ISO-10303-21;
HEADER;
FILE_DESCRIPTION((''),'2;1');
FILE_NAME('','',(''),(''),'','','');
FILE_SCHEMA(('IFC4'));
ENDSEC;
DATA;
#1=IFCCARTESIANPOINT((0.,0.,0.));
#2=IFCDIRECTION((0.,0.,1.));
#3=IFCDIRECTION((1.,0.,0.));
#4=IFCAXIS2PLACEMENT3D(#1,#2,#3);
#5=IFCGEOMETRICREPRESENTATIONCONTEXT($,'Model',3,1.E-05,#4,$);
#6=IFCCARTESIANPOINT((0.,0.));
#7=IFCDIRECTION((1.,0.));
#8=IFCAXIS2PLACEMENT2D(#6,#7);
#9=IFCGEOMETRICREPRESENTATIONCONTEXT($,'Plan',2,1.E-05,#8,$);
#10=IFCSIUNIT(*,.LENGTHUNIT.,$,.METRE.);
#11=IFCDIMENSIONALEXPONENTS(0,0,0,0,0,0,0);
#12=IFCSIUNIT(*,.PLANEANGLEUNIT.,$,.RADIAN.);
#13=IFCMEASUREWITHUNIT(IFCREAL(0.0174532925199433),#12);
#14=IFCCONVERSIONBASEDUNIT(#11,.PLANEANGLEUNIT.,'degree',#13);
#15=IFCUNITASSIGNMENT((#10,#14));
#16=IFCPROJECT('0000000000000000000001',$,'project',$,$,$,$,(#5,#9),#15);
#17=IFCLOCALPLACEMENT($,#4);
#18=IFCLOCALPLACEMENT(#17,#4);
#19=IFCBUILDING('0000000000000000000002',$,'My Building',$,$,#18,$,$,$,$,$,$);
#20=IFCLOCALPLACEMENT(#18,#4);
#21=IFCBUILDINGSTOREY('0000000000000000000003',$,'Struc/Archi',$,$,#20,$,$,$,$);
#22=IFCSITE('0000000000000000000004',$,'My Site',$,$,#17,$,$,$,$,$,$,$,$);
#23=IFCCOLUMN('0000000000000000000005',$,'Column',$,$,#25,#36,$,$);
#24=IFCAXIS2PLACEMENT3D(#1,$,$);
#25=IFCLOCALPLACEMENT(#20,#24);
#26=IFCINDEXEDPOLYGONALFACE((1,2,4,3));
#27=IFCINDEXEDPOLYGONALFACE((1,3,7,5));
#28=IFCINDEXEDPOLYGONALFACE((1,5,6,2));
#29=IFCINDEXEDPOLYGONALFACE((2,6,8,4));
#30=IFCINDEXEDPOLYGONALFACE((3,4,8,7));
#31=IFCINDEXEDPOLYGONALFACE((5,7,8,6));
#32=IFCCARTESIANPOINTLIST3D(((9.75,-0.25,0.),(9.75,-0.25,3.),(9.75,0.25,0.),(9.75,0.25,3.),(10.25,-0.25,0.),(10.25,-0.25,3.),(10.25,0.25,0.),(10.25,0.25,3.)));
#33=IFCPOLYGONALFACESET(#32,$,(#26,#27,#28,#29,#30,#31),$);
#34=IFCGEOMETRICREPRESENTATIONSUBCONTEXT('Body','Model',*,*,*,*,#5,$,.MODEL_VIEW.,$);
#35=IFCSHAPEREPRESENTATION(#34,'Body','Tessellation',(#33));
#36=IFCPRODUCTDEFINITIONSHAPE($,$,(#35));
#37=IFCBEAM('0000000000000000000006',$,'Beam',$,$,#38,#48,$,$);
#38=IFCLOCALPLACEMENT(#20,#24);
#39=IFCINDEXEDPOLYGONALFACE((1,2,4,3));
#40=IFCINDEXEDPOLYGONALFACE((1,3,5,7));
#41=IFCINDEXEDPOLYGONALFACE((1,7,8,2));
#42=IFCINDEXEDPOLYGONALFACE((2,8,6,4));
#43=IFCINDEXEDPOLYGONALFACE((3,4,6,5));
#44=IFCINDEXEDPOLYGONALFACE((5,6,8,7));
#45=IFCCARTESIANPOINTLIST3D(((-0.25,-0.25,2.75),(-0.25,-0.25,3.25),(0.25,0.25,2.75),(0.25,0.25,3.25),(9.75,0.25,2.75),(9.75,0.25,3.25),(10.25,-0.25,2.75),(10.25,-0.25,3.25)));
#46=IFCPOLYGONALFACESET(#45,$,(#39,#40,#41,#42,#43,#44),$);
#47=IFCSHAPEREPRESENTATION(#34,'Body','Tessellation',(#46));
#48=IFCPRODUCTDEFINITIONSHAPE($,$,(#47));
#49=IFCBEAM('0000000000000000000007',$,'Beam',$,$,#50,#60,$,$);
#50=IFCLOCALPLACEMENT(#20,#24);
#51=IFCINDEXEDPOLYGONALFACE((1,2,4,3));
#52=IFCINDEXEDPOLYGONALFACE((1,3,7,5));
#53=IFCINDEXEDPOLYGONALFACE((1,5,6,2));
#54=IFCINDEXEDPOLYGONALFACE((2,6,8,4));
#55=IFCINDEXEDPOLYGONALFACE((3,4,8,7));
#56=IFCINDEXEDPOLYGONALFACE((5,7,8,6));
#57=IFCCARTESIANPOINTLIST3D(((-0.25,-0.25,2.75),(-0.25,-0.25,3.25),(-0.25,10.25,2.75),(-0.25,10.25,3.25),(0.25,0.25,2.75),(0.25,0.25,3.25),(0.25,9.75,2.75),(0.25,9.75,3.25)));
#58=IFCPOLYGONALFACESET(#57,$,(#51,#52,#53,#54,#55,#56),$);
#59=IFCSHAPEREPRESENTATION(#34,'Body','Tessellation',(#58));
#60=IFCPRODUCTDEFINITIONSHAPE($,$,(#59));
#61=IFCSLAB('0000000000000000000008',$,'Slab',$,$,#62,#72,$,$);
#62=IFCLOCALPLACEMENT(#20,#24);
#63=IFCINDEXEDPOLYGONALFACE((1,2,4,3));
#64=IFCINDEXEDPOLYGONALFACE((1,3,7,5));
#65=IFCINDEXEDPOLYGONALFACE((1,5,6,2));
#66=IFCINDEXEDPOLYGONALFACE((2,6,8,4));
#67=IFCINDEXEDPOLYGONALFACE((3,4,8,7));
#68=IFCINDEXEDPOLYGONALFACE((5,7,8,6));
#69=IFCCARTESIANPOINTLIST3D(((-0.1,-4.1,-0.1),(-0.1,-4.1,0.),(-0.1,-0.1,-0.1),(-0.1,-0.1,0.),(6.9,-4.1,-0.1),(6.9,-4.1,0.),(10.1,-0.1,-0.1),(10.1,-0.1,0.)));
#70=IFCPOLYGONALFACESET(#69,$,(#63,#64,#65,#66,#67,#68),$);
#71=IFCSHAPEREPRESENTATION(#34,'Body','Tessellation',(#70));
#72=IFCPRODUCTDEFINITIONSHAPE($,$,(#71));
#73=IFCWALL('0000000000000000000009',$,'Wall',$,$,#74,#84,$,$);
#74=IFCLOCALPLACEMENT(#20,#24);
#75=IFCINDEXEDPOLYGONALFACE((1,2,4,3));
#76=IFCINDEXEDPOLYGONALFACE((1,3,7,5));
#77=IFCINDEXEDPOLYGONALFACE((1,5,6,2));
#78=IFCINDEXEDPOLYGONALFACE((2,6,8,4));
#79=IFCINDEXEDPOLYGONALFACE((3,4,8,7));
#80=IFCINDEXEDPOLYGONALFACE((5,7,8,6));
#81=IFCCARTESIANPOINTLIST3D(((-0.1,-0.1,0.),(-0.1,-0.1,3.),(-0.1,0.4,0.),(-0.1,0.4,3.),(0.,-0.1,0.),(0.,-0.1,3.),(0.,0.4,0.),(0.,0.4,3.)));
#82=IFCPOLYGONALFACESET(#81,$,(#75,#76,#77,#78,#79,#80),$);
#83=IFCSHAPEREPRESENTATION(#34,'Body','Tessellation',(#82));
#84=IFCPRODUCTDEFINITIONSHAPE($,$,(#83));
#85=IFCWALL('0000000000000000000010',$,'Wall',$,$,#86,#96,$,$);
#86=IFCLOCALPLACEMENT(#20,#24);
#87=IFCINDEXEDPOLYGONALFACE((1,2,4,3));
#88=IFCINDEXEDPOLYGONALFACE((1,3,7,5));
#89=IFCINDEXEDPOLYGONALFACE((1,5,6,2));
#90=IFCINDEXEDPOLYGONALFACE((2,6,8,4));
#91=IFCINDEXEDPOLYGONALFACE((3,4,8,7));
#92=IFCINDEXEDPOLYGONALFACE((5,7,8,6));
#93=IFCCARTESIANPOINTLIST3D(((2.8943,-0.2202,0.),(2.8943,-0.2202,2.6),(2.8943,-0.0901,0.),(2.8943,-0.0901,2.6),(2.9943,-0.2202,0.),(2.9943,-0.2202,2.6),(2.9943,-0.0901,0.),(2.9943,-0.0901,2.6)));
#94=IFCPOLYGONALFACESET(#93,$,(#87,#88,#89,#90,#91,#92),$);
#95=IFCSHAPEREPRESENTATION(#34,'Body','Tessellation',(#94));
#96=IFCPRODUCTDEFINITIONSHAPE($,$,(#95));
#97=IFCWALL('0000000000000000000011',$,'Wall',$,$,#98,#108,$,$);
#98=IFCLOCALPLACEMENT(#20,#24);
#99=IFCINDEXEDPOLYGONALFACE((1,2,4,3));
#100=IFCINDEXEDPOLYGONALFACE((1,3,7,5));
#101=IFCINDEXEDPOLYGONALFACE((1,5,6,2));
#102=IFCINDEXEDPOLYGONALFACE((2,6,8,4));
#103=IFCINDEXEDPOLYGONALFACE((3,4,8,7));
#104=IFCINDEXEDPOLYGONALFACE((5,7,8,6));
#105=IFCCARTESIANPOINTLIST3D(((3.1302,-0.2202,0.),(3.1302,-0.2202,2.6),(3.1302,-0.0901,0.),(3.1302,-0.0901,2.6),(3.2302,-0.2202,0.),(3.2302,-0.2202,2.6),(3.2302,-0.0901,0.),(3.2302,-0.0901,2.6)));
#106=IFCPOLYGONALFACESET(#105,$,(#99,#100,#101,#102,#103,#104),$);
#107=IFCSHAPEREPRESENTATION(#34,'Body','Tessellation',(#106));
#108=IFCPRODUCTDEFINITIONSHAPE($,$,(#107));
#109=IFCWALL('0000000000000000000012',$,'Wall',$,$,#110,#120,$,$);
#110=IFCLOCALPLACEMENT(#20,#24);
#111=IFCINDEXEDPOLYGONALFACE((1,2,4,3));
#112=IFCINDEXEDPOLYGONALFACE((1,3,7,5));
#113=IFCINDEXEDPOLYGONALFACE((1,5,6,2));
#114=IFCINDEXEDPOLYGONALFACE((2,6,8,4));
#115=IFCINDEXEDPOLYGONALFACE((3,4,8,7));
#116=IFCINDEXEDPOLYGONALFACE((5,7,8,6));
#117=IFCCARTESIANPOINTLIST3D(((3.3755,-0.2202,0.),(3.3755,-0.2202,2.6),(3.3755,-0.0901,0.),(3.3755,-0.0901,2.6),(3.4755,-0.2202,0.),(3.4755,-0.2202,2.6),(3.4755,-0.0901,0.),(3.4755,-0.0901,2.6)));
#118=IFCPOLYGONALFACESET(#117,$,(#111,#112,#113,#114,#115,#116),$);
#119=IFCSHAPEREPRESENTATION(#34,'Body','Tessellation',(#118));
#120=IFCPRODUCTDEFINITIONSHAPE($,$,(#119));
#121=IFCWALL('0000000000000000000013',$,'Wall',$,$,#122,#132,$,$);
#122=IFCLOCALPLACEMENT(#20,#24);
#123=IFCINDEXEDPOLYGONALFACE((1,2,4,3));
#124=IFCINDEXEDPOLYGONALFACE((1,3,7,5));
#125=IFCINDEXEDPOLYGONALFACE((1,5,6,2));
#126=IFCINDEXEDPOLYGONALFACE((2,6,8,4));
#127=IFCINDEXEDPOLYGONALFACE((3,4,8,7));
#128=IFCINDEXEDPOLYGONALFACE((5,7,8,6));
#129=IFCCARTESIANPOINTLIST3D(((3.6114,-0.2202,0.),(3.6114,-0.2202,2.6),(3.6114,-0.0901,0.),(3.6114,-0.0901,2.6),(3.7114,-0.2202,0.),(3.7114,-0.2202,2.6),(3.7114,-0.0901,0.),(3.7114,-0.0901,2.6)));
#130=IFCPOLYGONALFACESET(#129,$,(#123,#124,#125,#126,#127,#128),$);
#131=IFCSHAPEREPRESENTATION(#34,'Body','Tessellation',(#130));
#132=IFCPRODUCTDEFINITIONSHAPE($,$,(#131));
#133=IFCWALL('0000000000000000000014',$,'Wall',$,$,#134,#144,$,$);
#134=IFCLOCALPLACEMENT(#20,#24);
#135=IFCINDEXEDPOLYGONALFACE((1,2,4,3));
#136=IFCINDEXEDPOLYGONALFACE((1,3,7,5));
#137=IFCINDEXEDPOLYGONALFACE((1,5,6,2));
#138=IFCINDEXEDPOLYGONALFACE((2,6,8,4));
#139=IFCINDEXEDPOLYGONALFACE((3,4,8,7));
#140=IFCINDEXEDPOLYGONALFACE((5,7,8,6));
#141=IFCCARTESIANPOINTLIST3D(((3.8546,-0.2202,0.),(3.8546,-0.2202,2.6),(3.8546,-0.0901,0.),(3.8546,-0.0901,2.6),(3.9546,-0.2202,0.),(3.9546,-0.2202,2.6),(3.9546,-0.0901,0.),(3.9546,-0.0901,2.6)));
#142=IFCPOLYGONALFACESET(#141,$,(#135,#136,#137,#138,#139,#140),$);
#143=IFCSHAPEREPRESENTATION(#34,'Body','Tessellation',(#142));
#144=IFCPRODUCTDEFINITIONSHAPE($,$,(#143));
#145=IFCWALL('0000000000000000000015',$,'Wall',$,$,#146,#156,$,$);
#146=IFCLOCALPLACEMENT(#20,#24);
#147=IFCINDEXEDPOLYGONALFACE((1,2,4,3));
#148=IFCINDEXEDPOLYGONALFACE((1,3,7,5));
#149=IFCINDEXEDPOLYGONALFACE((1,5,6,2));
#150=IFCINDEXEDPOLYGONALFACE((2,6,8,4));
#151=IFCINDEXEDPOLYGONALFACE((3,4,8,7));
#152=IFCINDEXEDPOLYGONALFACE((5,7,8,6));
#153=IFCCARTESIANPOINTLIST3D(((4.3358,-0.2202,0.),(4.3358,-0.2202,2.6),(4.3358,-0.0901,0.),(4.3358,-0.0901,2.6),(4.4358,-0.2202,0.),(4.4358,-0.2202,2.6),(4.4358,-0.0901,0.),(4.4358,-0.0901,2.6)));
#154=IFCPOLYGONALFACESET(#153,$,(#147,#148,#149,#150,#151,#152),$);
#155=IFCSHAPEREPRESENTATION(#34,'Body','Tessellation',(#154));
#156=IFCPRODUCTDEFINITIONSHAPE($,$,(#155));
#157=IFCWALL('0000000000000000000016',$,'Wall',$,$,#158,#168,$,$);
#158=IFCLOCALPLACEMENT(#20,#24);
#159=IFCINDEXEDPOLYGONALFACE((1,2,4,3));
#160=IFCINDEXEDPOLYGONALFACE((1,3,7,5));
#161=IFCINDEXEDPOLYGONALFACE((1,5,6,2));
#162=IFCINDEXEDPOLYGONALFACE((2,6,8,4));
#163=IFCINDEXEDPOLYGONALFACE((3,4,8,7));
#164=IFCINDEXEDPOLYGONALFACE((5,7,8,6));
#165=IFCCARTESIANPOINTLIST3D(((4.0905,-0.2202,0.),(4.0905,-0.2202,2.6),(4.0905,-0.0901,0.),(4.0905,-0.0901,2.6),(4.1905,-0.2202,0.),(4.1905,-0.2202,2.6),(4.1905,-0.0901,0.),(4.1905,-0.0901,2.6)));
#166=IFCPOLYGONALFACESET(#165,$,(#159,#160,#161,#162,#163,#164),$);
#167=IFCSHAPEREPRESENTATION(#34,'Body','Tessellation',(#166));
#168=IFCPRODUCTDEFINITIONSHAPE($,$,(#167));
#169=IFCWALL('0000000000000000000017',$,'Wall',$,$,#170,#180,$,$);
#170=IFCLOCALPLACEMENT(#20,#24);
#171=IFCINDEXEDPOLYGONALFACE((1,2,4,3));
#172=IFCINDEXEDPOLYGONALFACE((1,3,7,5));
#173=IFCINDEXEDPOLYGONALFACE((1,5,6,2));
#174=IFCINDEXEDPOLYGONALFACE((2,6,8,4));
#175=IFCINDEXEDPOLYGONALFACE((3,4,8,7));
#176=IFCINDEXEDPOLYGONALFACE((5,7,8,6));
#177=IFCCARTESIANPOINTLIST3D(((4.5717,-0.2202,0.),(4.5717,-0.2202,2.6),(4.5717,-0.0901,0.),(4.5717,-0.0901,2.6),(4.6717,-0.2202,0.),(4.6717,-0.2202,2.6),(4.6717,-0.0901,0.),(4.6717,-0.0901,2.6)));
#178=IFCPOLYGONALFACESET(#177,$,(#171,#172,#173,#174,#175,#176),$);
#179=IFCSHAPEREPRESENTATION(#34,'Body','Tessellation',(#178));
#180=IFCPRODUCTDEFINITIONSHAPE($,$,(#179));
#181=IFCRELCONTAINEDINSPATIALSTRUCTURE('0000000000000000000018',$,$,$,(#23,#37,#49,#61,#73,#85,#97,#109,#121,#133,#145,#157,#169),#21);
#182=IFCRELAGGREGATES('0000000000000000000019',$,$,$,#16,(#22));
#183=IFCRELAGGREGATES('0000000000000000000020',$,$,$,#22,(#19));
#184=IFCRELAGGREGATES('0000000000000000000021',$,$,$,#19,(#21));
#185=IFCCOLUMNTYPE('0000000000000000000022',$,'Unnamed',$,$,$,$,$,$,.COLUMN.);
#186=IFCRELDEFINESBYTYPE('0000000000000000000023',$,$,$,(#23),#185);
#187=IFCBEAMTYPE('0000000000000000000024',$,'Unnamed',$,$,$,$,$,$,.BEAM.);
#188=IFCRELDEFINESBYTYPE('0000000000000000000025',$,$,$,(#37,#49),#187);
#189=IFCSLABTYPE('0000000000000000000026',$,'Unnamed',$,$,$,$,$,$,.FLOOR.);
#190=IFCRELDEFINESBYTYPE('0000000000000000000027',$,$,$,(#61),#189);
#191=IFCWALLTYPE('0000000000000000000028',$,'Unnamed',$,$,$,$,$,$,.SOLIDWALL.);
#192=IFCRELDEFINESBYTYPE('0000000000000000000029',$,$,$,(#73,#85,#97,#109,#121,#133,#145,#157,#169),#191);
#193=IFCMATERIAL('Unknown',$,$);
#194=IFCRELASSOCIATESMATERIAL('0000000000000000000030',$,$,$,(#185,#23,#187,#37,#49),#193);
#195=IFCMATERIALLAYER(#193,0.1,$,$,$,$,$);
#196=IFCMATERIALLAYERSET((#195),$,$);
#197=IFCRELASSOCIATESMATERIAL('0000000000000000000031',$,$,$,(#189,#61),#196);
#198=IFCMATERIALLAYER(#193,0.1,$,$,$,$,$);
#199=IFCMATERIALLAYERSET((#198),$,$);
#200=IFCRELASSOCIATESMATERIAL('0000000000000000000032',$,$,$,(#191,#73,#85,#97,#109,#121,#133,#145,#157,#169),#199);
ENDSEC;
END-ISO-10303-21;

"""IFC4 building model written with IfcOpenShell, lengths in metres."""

from ifc_helpers import new_model, entity, si_unit, converted_unit, frame, origin_with_axes, origin_2d_with_axis, place, context, subcontext, project, spatial, line, indexed_curve, rectangle, outline, extrude, clip, halfspace, material, layer, layer_set, layer_usage, material_profile, profile_set, profile_usage, type_object, element, save


model = new_model("IFC4")

# Units and contexts
model_context = context("Model", 3, precision=1e-05, world=origin_with_axes())
plan_context = context("Plan", 2, precision=1e-05, world=origin_2d_with_axis())
body_context_1 = subcontext(model_context, "Body", "Model", "MODEL_VIEW")
ifc_project = project(units=[si_unit("LENGTHUNIT", "METRE"), converted_unit("PLANEANGLEUNIT", "degree", entity("IfcReal", 0.0174532925199433), si_unit("PLANEANGLEUNIT", "RADIAN"), dimensions=[0, 0, 0, 0, 0, 0, 0])], contexts=[model_context, plan_context])

# Site, building, storey
site_placement = place(None, origin_with_axes())
site = spatial("IfcSite", under=ifc_project, at=site_placement, Name="My Site")
building_placement = place(site_placement, origin_with_axes())
building = spatial("IfcBuilding", under=site, at=building_placement, Name="My Building")
storey_placement = place(building_placement, origin_with_axes())
storey = spatial("IfcBuildingStorey", under=building, at=storey_placement, Name="Struc/Archi")

# Column
ifc_material = material(Name="Unknown")
ifc_material_profile_1 = material_profile(ifc_material, rectangle(XDim=0.5, YDim=0.5))
ifc_profile_set_1 = profile_set([ifc_material_profile_1])
ifc_profile_usage_1 = profile_usage(ifc_profile_set_1, cardinal=5)
column_type = type_object("IfcColumnType", Name="Unnamed", PredefinedType="COLUMN", material=ifc_profile_set_1)
column_placement = place(storey_placement, frame((10.0, 0.0, 0.0), z_axis=(0.0, 0.0, 1.0), x_axis=(1.0, 0.0, 0.0)))
element("IfcColumn", 1, at=column_placement, inside=storey, type_object=column_type, material=ifc_profile_usage_1, Name="Column", context=body_context_1, shape_type="SweptSolid", body=[
    extrude(rectangle(XDim=0.5, YDim=0.5), origin_with_axes(), (0.0, 0.0, 1.0), 3.0),
])

# Beams
ifc_material_profile_2 = material_profile(ifc_material, rectangle(XDim=0.5, YDim=0.5))
ifc_profile_set_2 = profile_set([ifc_material_profile_2])
ifc_profile_usage_2 = profile_usage(ifc_profile_set_2, cardinal=5)
beam_type = type_object("IfcBeamType", Name="Unnamed", PredefinedType="BEAM", material=ifc_profile_set_2)
beam_1_placement = place(storey_placement, frame((10.25, 0.0, 3.0), z_axis=(-1.0, 0.0, 0.0), x_axis=(0.0, -1.0, 0.0)))
element("IfcBeam", 2, at=beam_1_placement, inside=storey, type_object=beam_type, material=ifc_profile_usage_2, Name="Beam", context=body_context_1, shape_type="Clipping", body=[
    clip(clip(extrude(rectangle(XDim=0.5, YDim=0.5), origin_with_axes(), (0.0, 0.0, 1.0), 10.5), halfspace(frame((0.25, -3.0, 10.5), z_axis=(-0.707107, 0.0, 0.707107), x_axis=(0.0, 1.0, 0.0)), False)), halfspace(frame((0.25, -3.0, 0.0), z_axis=(-0.707107, 0.0, -0.707107), x_axis=(0.0, 1.0, 0.0)), False)),
])
ifc_profile_usage_3 = profile_usage(ifc_profile_set_2, cardinal=5)
beam_2_placement = place(storey_placement, frame((0.0, -0.25, 3.0), z_axis=(0.0, 1.0, 0.0), x_axis=(-1.0, 0.0, 0.0)))
element("IfcBeam", 3, at=beam_2_placement, inside=storey, type_object=beam_type, material=ifc_profile_usage_3, Name="Beam", context=body_context_1, shape_type="Clipping", body=[
    clip(clip(extrude(rectangle(XDim=0.5, YDim=0.5), origin_with_axes(), (0.0, 0.0, 1.0), 10.5), halfspace(frame((0.25, -3.0, 10.5), z_axis=(-0.707107, 0.0, 0.707107), x_axis=(0.0, 1.0, 0.0)), False)), halfspace(frame((0.25, -3.0, 0.0), z_axis=(-0.707107, 0.0, -0.707107), x_axis=(0.0, 1.0, 0.0)), False)),
])

# Slab
ifc_layer_1 = layer(ifc_material, 0.1)
ifc_layer_set_1 = layer_set([ifc_layer_1])
ifc_layer_usage_1 = layer_usage(ifc_layer_set_1, "AXIS3", "POSITIVE", -0.1)
slab_type = type_object("IfcSlabType", Name="Unnamed", PredefinedType="FLOOR", material=ifc_layer_set_1)
slab_placement = place(storey_placement, frame((-0.1, -0.1, 0.0), z_axis=(0.0, 0.0, 1.0), x_axis=(1.0, 0.0, 0.0)))
element("IfcSlab", 4, at=slab_placement, inside=storey, type_object=slab_type, material=ifc_layer_usage_1, Name="Slab", context=body_context_1, shape_type="SweptSolid", body=[
    extrude(outline(indexed_curve([(0.0, 0.0), (0.0, -4.0), (7.0, -4.0), (10.2, 0.0), (0.0, 0.0)])), frame((0.0, 0.0, -0.1), z_axis=(0.0, 0.0, 1.0), x_axis=(1.0, 0.0, 0.0)), (0.0, 0.0, 1.0), 0.1),
])

# Shared definitions
ifc_layer_2 = layer(ifc_material, 0.1)
ifc_layer_set_2 = layer_set([ifc_layer_2])
wall_type = type_object("IfcWallType", Name="Unnamed", PredefinedType="SOLIDWALL", material=ifc_layer_set_2)

# Walls
ifc_layer_usage_2 = layer_usage(ifc_layer_set_2, "AXIS2", "POSITIVE", 0.0)
wall_1_placement = place(storey_placement, frame((0.0, -0.1, 0.0), z_axis=(0.0, 0.0, 1.0), x_axis=(0.0, 1.0, 0.0)))
element("IfcWall", 5, at=wall_1_placement, inside=storey, type_object=wall_type, material=ifc_layer_usage_2, Name="Wall", context=body_context_1, shape_type="SweptSolid", body=[
    extrude(outline(indexed_curve([(0.0, 0.0), (0.0, 0.1), (0.5, 0.1), (0.5, 0.0)], segments=[line(1, 2, 3, 4, 1)])), origin_with_axes(), (0.0, 0.0, 1.0), 3.0),
])
ifc_layer_usage_3 = layer_usage(ifc_layer_set_2, "AXIS2", "POSITIVE", 0.0)
wall_2_placement = place(storey_placement, frame((2.8943, -0.0901, 0.0), z_axis=(0.0, 0.0, 1.0), x_axis=(0.0, -1.0, 0.0)))
element("IfcWall", 6, at=wall_2_placement, inside=storey, type_object=wall_type, material=ifc_layer_usage_3, Name="Wall", context=body_context_1, shape_type="SweptSolid", body=[
    extrude(outline(indexed_curve([(0.0, 0.0), (0.0, 0.1), (0.1301, 0.1), (0.1301, 0.0)], segments=[line(1, 2, 3, 4, 1)])), origin_with_axes(), (0.0, 0.0, 1.0), 2.6),
])
ifc_layer_usage_4 = layer_usage(ifc_layer_set_2, "AXIS2", "POSITIVE", 0.0)
wall_3_placement = place(storey_placement, frame((3.1302, -0.0901, 0.0), z_axis=(0.0, 0.0, 1.0), x_axis=(0.0, -1.0, 0.0)))
element("IfcWall", 7, at=wall_3_placement, inside=storey, type_object=wall_type, material=ifc_layer_usage_4, Name="Wall", context=body_context_1, shape_type="SweptSolid", body=[
    extrude(outline(indexed_curve([(0.0, 0.0), (0.0, 0.1), (0.1301, 0.1), (0.1301, 0.0)], segments=[line(1, 2, 3, 4, 1)])), origin_with_axes(), (0.0, 0.0, 1.0), 2.6),
])
ifc_layer_usage_5 = layer_usage(ifc_layer_set_2, "AXIS2", "POSITIVE", 0.0)
wall_4_placement = place(storey_placement, frame((3.3755, -0.0901, 0.0), z_axis=(0.0, 0.0, 1.0), x_axis=(0.0, -1.0, 0.0)))
element("IfcWall", 8, at=wall_4_placement, inside=storey, type_object=wall_type, material=ifc_layer_usage_5, Name="Wall", context=body_context_1, shape_type="SweptSolid", body=[
    extrude(outline(indexed_curve([(0.0, 0.0), (0.0, 0.1), (0.1301, 0.1), (0.1301, 0.0)], segments=[line(1, 2, 3, 4, 1)])), origin_with_axes(), (0.0, 0.0, 1.0), 2.6),
])
ifc_layer_usage_6 = layer_usage(ifc_layer_set_2, "AXIS2", "POSITIVE", 0.0)
wall_5_placement = place(storey_placement, frame((3.6114, -0.0901, 0.0), z_axis=(0.0, 0.0, 1.0), x_axis=(0.0, -1.0, 0.0)))
element("IfcWall", 9, at=wall_5_placement, inside=storey, type_object=wall_type, material=ifc_layer_usage_6, Name="Wall", context=body_context_1, shape_type="SweptSolid", body=[
    extrude(outline(indexed_curve([(0.0, 0.0), (0.0, 0.1), (0.1301, 0.1), (0.1301, 0.0)], segments=[line(1, 2, 3, 4, 1)])), origin_with_axes(), (0.0, 0.0, 1.0), 2.6),
])
ifc_layer_usage_7 = layer_usage(ifc_layer_set_2, "AXIS2", "POSITIVE", 0.0)
wall_6_placement = place(storey_placement, frame((3.8546, -0.0901, 0.0), z_axis=(0.0, 0.0, 1.0), x_axis=(0.0, -1.0, 0.0)))
element("IfcWall", 10, at=wall_6_placement, inside=storey, type_object=wall_type, material=ifc_layer_usage_7, Name="Wall", context=body_context_1, shape_type="SweptSolid", body=[
    extrude(outline(indexed_curve([(0.0, 0.0), (0.0, 0.1), (0.1301, 0.1), (0.1301, 0.0)], segments=[line(1, 2, 3, 4, 1)])), origin_with_axes(), (0.0, 0.0, 1.0), 2.6),
])
ifc_layer_usage_8 = layer_usage(ifc_layer_set_2, "AXIS2", "POSITIVE", 0.0)
wall_7_placement = place(storey_placement, frame((4.3358, -0.0901, 0.0), z_axis=(0.0, 0.0, 1.0), x_axis=(0.0, -1.0, 0.0)))
element("IfcWall", 11, at=wall_7_placement, inside=storey, type_object=wall_type, material=ifc_layer_usage_8, Name="Wall", context=body_context_1, shape_type="SweptSolid", body=[
    extrude(outline(indexed_curve([(0.0, 0.0), (0.0, 0.1), (0.1301, 0.1), (0.1301, 0.0)], segments=[line(1, 2, 3, 4, 1)])), origin_with_axes(), (0.0, 0.0, 1.0), 2.6),
])
ifc_layer_usage_9 = layer_usage(ifc_layer_set_2, "AXIS2", "POSITIVE", 0.0)
wall_8_placement = place(storey_placement, frame((4.0905, -0.0901, 0.0), z_axis=(0.0, 0.0, 1.0), x_axis=(0.0, -1.0, 0.0)))
element("IfcWall", 12, at=wall_8_placement, inside=storey, type_object=wall_type, material=ifc_layer_usage_9, Name="Wall", context=body_context_1, shape_type="SweptSolid", body=[
    extrude(outline(indexed_curve([(0.0, 0.0), (0.0, 0.1), (0.1301, 0.1), (0.1301, 0.0)], segments=[line(1, 2, 3, 4, 1)])), origin_with_axes(), (0.0, 0.0, 1.0), 2.6),
])
ifc_layer_usage_10 = layer_usage(ifc_layer_set_2, "AXIS2", "POSITIVE", 0.0)
wall_9_placement = place(storey_placement, frame((4.5717, -0.0901, 0.0), z_axis=(0.0, 0.0, 1.0), x_axis=(0.0, -1.0, 0.0)))
element("IfcWall", 13, at=wall_9_placement, inside=storey, type_object=wall_type, material=ifc_layer_usage_10, Name="Wall", context=body_context_1, shape_type="SweptSolid", body=[
    extrude(outline(indexed_curve([(0.0, 0.0), (0.0, 0.1), (0.1301, 0.1), (0.1301, 0.0)], segments=[line(1, 2, 3, 4, 1)])), origin_with_axes(), (0.0, 0.0, 1.0), 2.6),
])

save(model, "model.ifc")
